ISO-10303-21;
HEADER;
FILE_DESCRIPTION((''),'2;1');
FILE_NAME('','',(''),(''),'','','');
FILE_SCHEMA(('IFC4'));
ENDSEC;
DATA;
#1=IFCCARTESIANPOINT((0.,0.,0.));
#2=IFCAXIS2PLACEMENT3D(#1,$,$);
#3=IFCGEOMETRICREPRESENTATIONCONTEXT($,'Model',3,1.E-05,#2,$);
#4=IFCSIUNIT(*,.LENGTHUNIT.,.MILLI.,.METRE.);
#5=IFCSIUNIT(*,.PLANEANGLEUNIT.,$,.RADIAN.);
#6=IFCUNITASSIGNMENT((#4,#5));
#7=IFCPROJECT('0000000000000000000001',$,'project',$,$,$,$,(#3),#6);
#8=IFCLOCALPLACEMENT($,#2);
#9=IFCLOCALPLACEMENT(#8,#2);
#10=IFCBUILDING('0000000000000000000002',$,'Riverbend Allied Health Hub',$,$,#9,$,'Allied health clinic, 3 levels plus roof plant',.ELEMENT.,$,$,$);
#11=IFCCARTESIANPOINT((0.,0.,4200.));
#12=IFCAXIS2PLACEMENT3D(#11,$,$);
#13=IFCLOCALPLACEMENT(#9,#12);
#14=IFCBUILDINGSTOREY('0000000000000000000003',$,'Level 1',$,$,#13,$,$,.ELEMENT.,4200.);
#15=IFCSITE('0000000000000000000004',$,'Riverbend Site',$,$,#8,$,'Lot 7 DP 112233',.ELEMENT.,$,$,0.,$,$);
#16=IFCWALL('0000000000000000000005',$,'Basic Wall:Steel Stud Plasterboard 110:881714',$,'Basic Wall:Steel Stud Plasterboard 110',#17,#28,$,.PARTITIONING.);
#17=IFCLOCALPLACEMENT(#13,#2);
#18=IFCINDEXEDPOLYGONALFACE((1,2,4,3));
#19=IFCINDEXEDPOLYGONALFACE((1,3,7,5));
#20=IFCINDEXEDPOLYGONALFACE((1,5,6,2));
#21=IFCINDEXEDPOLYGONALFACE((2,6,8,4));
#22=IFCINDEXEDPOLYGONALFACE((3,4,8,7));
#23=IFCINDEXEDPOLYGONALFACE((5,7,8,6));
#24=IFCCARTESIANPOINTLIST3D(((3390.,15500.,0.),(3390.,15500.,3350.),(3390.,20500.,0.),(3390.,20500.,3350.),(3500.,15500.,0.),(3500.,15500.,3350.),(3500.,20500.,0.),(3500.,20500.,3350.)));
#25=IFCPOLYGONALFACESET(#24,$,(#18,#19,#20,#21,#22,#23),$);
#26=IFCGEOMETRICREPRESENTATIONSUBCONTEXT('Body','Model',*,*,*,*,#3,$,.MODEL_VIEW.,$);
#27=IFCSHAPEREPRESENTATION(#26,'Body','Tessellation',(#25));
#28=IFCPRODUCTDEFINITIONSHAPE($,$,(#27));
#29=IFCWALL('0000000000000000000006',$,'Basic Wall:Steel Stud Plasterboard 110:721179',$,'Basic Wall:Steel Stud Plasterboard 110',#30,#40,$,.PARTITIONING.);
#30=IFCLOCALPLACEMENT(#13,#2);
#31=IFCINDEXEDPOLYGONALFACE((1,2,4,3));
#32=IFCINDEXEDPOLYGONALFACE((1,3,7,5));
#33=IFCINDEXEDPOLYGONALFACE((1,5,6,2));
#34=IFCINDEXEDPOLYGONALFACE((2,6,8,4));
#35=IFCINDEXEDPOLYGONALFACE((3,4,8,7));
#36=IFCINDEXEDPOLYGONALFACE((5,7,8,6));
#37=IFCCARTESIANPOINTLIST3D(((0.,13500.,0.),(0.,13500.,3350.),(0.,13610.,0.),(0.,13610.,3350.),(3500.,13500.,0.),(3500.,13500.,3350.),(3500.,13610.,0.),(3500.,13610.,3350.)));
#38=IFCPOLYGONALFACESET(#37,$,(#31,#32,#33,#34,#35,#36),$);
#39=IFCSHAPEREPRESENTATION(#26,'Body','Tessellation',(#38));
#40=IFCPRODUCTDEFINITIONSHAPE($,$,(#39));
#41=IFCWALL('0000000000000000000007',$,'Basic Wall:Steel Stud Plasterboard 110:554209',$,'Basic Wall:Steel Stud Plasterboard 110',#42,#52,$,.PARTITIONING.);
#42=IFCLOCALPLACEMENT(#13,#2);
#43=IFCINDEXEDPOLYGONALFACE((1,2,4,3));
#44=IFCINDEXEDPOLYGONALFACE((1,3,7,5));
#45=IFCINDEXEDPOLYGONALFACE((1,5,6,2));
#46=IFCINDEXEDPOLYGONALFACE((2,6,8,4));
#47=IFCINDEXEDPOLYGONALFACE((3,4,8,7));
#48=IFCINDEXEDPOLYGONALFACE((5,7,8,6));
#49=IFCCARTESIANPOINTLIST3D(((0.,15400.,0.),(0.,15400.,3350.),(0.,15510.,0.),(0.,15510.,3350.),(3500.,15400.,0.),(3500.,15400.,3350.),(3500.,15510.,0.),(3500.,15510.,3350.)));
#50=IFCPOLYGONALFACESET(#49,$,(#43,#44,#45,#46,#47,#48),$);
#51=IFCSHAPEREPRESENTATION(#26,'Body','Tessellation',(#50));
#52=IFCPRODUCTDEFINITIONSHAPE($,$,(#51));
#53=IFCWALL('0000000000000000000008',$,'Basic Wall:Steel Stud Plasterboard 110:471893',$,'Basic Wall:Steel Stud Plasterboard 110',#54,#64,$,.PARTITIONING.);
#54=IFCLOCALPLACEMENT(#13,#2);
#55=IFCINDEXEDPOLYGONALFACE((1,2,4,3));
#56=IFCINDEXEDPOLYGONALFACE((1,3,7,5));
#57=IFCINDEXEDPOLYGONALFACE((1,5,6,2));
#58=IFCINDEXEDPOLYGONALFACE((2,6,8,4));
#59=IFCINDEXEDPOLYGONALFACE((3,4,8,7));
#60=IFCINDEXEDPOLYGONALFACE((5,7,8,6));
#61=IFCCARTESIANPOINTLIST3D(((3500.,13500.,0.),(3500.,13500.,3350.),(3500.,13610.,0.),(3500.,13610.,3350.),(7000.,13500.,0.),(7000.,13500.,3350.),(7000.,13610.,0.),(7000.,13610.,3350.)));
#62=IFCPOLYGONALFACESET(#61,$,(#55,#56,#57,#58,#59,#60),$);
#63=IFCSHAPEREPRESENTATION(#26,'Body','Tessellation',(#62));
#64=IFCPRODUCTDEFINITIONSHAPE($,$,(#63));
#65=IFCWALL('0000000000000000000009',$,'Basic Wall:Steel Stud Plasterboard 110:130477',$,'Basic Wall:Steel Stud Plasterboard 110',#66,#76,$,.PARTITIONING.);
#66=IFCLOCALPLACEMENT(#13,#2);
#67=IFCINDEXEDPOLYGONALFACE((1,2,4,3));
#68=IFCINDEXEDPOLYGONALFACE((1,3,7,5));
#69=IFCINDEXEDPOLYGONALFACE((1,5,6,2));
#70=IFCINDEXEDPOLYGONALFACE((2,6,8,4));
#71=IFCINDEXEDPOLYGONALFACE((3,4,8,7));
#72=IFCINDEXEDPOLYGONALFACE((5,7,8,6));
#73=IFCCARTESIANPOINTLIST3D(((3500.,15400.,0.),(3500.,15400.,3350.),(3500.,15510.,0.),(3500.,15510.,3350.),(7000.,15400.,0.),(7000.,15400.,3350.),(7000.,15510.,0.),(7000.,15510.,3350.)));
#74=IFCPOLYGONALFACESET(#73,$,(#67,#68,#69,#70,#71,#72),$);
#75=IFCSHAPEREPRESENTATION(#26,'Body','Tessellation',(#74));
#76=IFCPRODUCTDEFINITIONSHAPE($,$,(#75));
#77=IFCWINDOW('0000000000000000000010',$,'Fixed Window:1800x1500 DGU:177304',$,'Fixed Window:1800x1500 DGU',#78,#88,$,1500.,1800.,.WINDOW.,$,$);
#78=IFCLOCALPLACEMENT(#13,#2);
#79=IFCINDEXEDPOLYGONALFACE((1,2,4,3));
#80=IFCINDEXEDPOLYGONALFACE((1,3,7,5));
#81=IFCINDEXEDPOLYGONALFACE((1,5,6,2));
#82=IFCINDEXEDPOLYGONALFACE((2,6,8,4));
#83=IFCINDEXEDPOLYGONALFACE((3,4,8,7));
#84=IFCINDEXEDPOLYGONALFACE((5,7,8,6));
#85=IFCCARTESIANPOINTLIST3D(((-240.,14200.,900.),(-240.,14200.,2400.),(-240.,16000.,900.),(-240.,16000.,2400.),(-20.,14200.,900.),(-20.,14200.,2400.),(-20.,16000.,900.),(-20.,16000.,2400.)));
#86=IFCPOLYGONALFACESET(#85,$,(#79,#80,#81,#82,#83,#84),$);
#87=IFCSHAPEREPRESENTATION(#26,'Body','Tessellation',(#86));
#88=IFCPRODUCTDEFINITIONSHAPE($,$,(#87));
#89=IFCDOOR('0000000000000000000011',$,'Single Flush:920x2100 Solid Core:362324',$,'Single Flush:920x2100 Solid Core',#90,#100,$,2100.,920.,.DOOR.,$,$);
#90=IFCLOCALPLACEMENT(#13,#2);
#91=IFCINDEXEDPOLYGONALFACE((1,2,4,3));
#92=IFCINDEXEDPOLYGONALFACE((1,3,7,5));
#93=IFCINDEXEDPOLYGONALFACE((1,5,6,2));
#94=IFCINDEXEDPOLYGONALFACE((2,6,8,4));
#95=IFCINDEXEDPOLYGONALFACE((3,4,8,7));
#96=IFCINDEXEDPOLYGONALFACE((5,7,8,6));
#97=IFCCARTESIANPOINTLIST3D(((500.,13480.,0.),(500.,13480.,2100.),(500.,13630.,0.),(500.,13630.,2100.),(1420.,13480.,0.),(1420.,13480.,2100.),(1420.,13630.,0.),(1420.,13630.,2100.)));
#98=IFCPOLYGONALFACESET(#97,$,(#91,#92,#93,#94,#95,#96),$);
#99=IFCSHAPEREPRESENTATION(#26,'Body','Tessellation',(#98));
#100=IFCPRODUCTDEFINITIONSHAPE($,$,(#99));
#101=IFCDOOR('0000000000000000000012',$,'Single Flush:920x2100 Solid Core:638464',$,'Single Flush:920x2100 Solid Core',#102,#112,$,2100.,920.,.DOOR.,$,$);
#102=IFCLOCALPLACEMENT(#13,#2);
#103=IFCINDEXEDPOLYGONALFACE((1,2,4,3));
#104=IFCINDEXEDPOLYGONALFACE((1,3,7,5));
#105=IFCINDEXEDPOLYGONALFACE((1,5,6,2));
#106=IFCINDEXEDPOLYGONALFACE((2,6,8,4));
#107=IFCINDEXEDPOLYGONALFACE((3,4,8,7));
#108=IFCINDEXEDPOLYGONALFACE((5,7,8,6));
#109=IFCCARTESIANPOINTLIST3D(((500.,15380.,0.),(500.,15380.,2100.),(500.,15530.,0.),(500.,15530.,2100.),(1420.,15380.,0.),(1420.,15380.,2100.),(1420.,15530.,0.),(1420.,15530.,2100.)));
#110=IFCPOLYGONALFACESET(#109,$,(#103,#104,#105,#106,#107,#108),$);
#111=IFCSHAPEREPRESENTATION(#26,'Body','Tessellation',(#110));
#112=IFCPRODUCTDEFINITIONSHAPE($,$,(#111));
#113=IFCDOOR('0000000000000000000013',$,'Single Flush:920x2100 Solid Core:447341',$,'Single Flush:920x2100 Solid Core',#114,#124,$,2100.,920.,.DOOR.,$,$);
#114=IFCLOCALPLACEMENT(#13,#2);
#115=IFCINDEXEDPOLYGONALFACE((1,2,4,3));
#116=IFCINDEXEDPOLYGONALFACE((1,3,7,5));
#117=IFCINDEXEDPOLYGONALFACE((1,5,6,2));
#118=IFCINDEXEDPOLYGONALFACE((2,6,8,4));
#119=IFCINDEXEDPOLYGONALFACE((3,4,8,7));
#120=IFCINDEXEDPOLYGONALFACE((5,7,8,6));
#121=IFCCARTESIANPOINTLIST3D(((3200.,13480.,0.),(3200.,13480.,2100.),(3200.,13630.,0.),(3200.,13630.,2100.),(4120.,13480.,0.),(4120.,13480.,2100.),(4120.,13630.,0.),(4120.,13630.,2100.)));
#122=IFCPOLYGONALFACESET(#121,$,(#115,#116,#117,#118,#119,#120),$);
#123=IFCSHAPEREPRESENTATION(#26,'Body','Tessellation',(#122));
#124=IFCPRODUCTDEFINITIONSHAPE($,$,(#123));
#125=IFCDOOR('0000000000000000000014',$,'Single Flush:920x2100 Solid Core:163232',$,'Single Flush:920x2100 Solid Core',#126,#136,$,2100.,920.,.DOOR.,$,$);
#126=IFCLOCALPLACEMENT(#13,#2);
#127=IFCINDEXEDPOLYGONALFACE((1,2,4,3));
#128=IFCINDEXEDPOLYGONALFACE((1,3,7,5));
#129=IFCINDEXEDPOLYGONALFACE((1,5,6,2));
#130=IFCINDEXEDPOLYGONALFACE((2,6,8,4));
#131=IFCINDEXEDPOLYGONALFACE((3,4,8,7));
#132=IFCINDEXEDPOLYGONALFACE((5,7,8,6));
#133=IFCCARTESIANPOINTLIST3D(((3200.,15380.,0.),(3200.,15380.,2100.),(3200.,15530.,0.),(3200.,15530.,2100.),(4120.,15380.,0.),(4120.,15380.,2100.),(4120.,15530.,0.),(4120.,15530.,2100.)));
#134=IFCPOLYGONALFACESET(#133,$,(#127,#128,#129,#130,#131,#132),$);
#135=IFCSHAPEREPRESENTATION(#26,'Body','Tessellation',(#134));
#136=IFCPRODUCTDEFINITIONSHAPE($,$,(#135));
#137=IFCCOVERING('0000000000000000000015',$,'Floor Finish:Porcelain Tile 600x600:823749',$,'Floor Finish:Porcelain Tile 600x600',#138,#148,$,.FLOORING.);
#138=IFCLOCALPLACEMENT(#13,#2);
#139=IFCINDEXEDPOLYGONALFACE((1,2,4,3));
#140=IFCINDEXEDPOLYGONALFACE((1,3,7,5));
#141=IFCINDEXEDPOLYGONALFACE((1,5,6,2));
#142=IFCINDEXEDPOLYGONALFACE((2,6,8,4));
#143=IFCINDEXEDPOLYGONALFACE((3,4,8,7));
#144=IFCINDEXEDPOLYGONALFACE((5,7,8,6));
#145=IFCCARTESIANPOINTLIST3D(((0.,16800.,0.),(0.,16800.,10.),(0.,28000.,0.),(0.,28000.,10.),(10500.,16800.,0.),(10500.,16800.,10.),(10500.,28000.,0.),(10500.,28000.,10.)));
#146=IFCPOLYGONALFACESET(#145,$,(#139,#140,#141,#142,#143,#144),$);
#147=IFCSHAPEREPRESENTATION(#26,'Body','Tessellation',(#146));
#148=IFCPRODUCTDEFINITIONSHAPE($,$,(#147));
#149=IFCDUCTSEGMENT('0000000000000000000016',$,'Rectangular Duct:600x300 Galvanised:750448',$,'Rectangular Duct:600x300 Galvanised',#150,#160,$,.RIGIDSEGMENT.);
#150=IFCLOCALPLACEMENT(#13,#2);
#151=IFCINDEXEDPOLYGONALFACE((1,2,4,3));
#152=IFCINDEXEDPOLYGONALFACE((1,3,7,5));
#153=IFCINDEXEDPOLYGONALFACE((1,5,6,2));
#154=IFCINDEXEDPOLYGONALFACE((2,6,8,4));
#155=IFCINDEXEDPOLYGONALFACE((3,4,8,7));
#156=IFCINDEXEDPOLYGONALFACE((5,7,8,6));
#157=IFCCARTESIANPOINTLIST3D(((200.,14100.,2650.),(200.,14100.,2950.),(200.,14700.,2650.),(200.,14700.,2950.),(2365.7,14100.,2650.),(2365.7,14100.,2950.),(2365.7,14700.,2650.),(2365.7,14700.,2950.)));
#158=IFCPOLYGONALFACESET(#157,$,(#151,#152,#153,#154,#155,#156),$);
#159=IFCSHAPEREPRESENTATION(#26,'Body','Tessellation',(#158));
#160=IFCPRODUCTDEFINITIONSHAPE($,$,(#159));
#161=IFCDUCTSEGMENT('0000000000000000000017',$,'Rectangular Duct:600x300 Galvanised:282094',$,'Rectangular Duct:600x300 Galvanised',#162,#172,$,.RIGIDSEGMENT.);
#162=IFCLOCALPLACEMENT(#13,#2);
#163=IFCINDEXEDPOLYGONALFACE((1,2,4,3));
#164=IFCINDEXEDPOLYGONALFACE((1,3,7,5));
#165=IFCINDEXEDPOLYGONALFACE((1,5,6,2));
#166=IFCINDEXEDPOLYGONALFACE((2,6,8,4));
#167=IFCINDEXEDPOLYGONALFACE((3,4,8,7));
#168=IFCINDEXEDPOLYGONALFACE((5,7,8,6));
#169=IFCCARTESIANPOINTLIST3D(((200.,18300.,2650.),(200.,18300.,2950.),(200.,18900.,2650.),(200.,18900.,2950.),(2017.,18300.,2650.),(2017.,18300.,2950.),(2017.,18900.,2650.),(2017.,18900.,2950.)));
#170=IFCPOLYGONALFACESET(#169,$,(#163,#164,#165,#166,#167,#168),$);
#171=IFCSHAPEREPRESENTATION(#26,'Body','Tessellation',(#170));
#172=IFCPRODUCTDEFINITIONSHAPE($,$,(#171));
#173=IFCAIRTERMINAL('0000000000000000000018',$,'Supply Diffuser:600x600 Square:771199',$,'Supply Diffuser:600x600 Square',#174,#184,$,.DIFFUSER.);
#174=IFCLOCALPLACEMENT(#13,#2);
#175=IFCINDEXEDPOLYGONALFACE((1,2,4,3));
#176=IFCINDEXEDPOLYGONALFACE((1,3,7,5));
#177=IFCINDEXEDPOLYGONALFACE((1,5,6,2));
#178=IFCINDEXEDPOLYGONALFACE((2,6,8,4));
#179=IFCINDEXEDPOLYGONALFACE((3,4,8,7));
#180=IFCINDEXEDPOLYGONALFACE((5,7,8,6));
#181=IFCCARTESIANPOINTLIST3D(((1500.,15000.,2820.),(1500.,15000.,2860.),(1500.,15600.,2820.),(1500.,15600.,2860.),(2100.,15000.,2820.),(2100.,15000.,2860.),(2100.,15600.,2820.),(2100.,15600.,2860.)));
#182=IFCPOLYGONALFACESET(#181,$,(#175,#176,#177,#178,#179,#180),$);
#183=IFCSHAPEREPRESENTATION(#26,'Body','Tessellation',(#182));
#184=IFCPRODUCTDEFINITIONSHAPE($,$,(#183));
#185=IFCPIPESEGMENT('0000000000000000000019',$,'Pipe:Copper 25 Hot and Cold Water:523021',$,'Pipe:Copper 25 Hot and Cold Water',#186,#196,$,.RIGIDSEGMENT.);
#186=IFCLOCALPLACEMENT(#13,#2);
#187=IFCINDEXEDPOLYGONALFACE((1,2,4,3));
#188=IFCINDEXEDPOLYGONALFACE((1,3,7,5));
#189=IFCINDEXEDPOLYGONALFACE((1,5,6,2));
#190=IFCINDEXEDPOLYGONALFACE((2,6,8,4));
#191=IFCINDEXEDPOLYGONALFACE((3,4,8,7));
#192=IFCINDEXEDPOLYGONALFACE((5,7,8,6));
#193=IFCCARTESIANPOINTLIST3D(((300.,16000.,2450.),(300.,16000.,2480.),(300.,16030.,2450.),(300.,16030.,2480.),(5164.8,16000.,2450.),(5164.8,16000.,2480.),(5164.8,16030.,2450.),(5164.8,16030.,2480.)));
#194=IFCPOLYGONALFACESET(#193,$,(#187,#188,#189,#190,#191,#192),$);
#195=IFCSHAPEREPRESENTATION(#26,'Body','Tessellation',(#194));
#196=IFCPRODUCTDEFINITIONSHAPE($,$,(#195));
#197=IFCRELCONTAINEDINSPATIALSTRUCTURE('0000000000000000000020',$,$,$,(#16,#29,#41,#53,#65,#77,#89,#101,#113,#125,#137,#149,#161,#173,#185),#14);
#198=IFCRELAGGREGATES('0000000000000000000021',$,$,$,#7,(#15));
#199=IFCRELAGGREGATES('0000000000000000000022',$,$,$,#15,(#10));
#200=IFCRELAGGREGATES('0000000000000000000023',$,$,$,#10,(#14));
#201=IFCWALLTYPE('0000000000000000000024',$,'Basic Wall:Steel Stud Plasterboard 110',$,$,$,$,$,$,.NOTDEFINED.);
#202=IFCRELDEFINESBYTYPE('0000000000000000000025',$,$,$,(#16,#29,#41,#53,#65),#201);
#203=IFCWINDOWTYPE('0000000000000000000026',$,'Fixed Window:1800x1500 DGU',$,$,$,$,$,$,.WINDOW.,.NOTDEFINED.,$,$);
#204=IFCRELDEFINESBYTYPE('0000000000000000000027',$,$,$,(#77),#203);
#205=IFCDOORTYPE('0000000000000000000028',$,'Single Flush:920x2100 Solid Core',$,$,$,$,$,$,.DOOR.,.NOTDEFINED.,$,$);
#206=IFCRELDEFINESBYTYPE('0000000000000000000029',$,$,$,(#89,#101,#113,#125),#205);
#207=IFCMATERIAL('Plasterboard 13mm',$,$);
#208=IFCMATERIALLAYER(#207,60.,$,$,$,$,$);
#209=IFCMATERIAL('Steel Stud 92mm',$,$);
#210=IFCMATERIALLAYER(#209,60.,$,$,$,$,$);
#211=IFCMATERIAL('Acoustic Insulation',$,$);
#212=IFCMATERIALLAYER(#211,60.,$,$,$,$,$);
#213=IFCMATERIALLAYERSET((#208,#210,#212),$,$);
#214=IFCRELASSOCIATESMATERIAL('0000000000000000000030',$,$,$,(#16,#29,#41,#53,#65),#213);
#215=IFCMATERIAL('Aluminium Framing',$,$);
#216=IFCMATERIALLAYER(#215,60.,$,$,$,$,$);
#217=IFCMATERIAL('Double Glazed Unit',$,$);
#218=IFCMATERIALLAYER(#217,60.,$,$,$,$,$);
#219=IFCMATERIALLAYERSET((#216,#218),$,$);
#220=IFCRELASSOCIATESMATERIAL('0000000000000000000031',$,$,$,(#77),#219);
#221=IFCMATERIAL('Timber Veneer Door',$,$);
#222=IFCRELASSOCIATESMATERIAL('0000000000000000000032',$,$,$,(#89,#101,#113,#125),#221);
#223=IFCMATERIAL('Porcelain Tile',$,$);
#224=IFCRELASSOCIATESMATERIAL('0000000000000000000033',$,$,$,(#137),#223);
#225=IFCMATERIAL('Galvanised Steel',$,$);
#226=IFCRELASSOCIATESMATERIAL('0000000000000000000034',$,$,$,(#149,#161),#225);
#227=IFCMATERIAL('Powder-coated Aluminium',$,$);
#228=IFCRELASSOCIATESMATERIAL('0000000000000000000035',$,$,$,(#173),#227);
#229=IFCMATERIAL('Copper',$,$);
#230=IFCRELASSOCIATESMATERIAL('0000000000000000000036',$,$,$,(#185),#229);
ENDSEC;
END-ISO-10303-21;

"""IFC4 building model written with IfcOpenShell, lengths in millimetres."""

from ifc_helpers import new_model, si_unit, frame, frame_2d, origin, place, context, subcontext, project, spatial, rectangle, extrude, material, layer, layer_set, layer_usage, type_object, element, save


model = new_model("IFC4")

# Units and contexts
model_context = context("Model", 3, precision=1e-05, world=origin())
body_context = subcontext(model_context, "Body", "Model", "MODEL_VIEW")
ifc_project = project(units=[si_unit("LENGTHUNIT", "METRE", prefix="MILLI"), si_unit("PLANEANGLEUNIT", "RADIAN")], contexts=[model_context])

# Site, building, storey
site_placement = place(None, origin())
site = spatial("IfcSite", under=ifc_project, at=site_placement, Name="Riverbend Site", LongName="Lot 7 DP 112233", CompositionType="ELEMENT", RefElevation=0.0)
building_placement = place(site_placement, origin())
building = spatial("IfcBuilding", under=site, at=building_placement, Name="Riverbend Allied Health Hub", LongName="Allied health clinic, 3 levels plus roof plant", CompositionType="ELEMENT")
storey_placement = place(building_placement, frame((0.0, 0.0, 4200.0)))
storey = spatial("IfcBuildingStorey", under=building, at=storey_placement, Name="Level 1", CompositionType="ELEMENT", Elevation=4200.0)

# Walls
ifc_material_1 = material(Name="Plasterboard 13mm")
ifc_layer_1 = layer(ifc_material_1, 60.0)
ifc_material_2 = material(Name="Steel Stud 92mm")
ifc_layer_2 = layer(ifc_material_2, 60.0)
ifc_material_3 = material(Name="Acoustic Insulation")
ifc_layer_3 = layer(ifc_material_3, 60.0)
ifc_layer_set_1 = layer_set([ifc_layer_1, ifc_layer_2, ifc_layer_3])
ifc_layer_usage_1 = layer_usage(ifc_layer_set_1, "AXIS2", "POSITIVE", 0.0)
wall_type = type_object("IfcWallType", Name="Basic Wall:Steel Stud Plasterboard 110", PredefinedType="NOTDEFINED")
wall_placement = place(storey_placement, frame((3500.0, 15500.0, 0.0), z_axis=(0.0, 0.0, 1.0), x_axis=(0.0, 1.0, 0.0)))
element("IfcWall", 1, at=wall_placement, inside=storey, type_object=wall_type, material=ifc_layer_usage_1, Name="Basic Wall:Steel Stud Plasterboard 110:881714", ObjectType="Basic Wall:Steel Stud Plasterboard 110", PredefinedType="PARTITIONING", context=body_context, shape_type="SweptSolid", body=[
    extrude(rectangle(XDim=5000.0, YDim=110.0, at=frame_2d((2500.0, 55.0))), origin(), (0.0, 0.0, 1.0), 3350.0),
])
for number, where, name in (
    (2, (0.0, 13500.0, 0.0), "Basic Wall:Steel Stud Plasterboard 110:721179"),
    (3, (0.0, 15400.0, 0.0), "Basic Wall:Steel Stud Plasterboard 110:554209"),
    (4, (3500.0, 13500.0, 0.0), "Basic Wall:Steel Stud Plasterboard 110:471893"),
    (5, (3500.0, 15400.0, 0.0), "Basic Wall:Steel Stud Plasterboard 110:130477"),
):
    element("IfcWall", number, at=place(storey_placement, frame(where)), inside=storey, type_object=wall_type, material=ifc_layer_usage_1, Name=name, ObjectType="Basic Wall:Steel Stud Plasterboard 110", PredefinedType="PARTITIONING", context=body_context, shape_type="SweptSolid", body=[
        extrude(rectangle(XDim=3500.0, YDim=110.0, at=frame_2d((1750.0, 55.0))), origin(), (0.0, 0.0, 1.0), 3350.0),
    ])

# Window
ifc_material_4 = material(Name="Aluminium Framing")
ifc_layer_4 = layer(ifc_material_4, 60.0)
ifc_material_5 = material(Name="Double Glazed Unit")
ifc_layer_5 = layer(ifc_material_5, 60.0)
ifc_layer_set_2 = layer_set([ifc_layer_4, ifc_layer_5])
ifc_layer_usage_2 = layer_usage(ifc_layer_set_2, "AXIS2", "POSITIVE", 0.0)
window_type = type_object("IfcWindowType", Name="Fixed Window:1800x1500 DGU", PartitioningType="NOTDEFINED", PredefinedType="WINDOW")
window_placement = place(storey_placement, frame((-20.0, 14200.0, 900.0), z_axis=(0.0, 0.0, 1.0), x_axis=(0.0, 1.0, 0.0)))
element("IfcWindow", 6, at=window_placement, inside=storey, type_object=window_type, material=ifc_layer_usage_2, Name="Fixed Window:1800x1500 DGU:177304", ObjectType="Fixed Window:1800x1500 DGU", OverallHeight=1500.0, OverallWidth=1800.0, PredefinedType="WINDOW", context=body_context, shape_type="SweptSolid", body=[
    extrude(rectangle(XDim=1800.0, YDim=220.0, at=frame_2d((900.0, 110.0))), origin(), (0.0, 0.0, 1.0), 1500.0),
])

# Doors
ifc_material_6 = material(Name="Timber Veneer Door")
door_type = type_object("IfcDoorType", Name="Single Flush:920x2100 Solid Core", OperationType="NOTDEFINED", PredefinedType="DOOR")
for number, where, name in (
    (7, (500.0, 13480.0, 0.0), "Single Flush:920x2100 Solid Core:362324"),
    (8, (500.0, 15380.0, 0.0), "Single Flush:920x2100 Solid Core:638464"),
    (9, (3200.0, 13480.0, 0.0), "Single Flush:920x2100 Solid Core:447341"),
    (10, (3200.0, 15380.0, 0.0), "Single Flush:920x2100 Solid Core:163232"),
):
    element("IfcDoor", number, at=place(storey_placement, frame(where)), inside=storey, type_object=door_type, material=ifc_material_6, Name=name, ObjectType="Single Flush:920x2100 Solid Core", OverallHeight=2100.0, OverallWidth=920.0, PredefinedType="DOOR", context=body_context, shape_type="SweptSolid", body=[
        extrude(rectangle(XDim=920.0, YDim=150.0, at=frame_2d((460.0, 75.0))), origin(), (0.0, 0.0, 1.0), 2100.0),
    ])

# Covering
ifc_material_7 = material(Name="Porcelain Tile")
covering_placement = place(storey_placement, frame((0.0, 16800.0, 0.0)))
element("IfcCovering", 11, at=covering_placement, inside=storey, material=ifc_material_7, Name="Floor Finish:Porcelain Tile 600x600:823749", ObjectType="Floor Finish:Porcelain Tile 600x600", PredefinedType="FLOORING", context=body_context, shape_type="SweptSolid", body=[
    extrude(rectangle(XDim=10500.0, YDim=11200.0, at=frame_2d((5250.0, 5600.0))), origin(), (0.0, 0.0, 1.0), 10.0),
])

# Duct segments
ifc_material_8 = material(Name="Galvanised Steel")
duct_segment_1_placement = place(storey_placement, frame((200.0, 14100.0, 2650.0)))
element("IfcDuctSegment", 12, at=duct_segment_1_placement, inside=storey, material=ifc_material_8, Name="Rectangular Duct:600x300 Galvanised:750448", ObjectType="Rectangular Duct:600x300 Galvanised", PredefinedType="RIGIDSEGMENT", context=body_context, shape_type="SweptSolid", body=[
    extrude(rectangle(XDim=2165.7, YDim=600.0, at=frame_2d((1082.8, 300.0))), origin(), (0.0, 0.0, 1.0), 300.0),
])
duct_segment_2_placement = place(storey_placement, frame((200.0, 18300.0, 2650.0)))
element("IfcDuctSegment", 13, at=duct_segment_2_placement, inside=storey, material=ifc_material_8, Name="Rectangular Duct:600x300 Galvanised:282094", ObjectType="Rectangular Duct:600x300 Galvanised", PredefinedType="RIGIDSEGMENT", context=body_context, shape_type="SweptSolid", body=[
    extrude(rectangle(XDim=1817.0, YDim=600.0, at=frame_2d((908.5, 300.0))), origin(), (0.0, 0.0, 1.0), 300.0),
])

# Air terminal
ifc_material_9 = material(Name="Powder-coated Aluminium")
air_terminal_placement = place(storey_placement, frame((1500.0, 15000.0, 2820.0)))
element("IfcAirTerminal", 14, at=air_terminal_placement, inside=storey, material=ifc_material_9, Name="Supply Diffuser:600x600 Square:771199", ObjectType="Supply Diffuser:600x600 Square", PredefinedType="DIFFUSER", context=body_context, shape_type="SweptSolid", body=[
    extrude(rectangle(XDim=600.0, YDim=600.0, at=frame_2d((300.0, 300.0))), origin(), (0.0, 0.0, 1.0), 40.0),
])

# Pipe segment
ifc_material_10 = material(Name="Copper")
pipe_segment_placement = place(storey_placement, frame((300.0, 16000.0, 2450.0)))
element("IfcPipeSegment", 15, at=pipe_segment_placement, inside=storey, material=ifc_material_10, Name="Pipe:Copper 25 Hot and Cold Water:523021", ObjectType="Pipe:Copper 25 Hot and Cold Water", PredefinedType="RIGIDSEGMENT", context=body_context, shape_type="SweptSolid", body=[
    extrude(rectangle(XDim=4864.8, YDim=30.0, at=frame_2d((2432.4, 15.0))), origin(), (0.0, 0.0, 1.0), 30.0),
])

save(model, "model.ifc")
